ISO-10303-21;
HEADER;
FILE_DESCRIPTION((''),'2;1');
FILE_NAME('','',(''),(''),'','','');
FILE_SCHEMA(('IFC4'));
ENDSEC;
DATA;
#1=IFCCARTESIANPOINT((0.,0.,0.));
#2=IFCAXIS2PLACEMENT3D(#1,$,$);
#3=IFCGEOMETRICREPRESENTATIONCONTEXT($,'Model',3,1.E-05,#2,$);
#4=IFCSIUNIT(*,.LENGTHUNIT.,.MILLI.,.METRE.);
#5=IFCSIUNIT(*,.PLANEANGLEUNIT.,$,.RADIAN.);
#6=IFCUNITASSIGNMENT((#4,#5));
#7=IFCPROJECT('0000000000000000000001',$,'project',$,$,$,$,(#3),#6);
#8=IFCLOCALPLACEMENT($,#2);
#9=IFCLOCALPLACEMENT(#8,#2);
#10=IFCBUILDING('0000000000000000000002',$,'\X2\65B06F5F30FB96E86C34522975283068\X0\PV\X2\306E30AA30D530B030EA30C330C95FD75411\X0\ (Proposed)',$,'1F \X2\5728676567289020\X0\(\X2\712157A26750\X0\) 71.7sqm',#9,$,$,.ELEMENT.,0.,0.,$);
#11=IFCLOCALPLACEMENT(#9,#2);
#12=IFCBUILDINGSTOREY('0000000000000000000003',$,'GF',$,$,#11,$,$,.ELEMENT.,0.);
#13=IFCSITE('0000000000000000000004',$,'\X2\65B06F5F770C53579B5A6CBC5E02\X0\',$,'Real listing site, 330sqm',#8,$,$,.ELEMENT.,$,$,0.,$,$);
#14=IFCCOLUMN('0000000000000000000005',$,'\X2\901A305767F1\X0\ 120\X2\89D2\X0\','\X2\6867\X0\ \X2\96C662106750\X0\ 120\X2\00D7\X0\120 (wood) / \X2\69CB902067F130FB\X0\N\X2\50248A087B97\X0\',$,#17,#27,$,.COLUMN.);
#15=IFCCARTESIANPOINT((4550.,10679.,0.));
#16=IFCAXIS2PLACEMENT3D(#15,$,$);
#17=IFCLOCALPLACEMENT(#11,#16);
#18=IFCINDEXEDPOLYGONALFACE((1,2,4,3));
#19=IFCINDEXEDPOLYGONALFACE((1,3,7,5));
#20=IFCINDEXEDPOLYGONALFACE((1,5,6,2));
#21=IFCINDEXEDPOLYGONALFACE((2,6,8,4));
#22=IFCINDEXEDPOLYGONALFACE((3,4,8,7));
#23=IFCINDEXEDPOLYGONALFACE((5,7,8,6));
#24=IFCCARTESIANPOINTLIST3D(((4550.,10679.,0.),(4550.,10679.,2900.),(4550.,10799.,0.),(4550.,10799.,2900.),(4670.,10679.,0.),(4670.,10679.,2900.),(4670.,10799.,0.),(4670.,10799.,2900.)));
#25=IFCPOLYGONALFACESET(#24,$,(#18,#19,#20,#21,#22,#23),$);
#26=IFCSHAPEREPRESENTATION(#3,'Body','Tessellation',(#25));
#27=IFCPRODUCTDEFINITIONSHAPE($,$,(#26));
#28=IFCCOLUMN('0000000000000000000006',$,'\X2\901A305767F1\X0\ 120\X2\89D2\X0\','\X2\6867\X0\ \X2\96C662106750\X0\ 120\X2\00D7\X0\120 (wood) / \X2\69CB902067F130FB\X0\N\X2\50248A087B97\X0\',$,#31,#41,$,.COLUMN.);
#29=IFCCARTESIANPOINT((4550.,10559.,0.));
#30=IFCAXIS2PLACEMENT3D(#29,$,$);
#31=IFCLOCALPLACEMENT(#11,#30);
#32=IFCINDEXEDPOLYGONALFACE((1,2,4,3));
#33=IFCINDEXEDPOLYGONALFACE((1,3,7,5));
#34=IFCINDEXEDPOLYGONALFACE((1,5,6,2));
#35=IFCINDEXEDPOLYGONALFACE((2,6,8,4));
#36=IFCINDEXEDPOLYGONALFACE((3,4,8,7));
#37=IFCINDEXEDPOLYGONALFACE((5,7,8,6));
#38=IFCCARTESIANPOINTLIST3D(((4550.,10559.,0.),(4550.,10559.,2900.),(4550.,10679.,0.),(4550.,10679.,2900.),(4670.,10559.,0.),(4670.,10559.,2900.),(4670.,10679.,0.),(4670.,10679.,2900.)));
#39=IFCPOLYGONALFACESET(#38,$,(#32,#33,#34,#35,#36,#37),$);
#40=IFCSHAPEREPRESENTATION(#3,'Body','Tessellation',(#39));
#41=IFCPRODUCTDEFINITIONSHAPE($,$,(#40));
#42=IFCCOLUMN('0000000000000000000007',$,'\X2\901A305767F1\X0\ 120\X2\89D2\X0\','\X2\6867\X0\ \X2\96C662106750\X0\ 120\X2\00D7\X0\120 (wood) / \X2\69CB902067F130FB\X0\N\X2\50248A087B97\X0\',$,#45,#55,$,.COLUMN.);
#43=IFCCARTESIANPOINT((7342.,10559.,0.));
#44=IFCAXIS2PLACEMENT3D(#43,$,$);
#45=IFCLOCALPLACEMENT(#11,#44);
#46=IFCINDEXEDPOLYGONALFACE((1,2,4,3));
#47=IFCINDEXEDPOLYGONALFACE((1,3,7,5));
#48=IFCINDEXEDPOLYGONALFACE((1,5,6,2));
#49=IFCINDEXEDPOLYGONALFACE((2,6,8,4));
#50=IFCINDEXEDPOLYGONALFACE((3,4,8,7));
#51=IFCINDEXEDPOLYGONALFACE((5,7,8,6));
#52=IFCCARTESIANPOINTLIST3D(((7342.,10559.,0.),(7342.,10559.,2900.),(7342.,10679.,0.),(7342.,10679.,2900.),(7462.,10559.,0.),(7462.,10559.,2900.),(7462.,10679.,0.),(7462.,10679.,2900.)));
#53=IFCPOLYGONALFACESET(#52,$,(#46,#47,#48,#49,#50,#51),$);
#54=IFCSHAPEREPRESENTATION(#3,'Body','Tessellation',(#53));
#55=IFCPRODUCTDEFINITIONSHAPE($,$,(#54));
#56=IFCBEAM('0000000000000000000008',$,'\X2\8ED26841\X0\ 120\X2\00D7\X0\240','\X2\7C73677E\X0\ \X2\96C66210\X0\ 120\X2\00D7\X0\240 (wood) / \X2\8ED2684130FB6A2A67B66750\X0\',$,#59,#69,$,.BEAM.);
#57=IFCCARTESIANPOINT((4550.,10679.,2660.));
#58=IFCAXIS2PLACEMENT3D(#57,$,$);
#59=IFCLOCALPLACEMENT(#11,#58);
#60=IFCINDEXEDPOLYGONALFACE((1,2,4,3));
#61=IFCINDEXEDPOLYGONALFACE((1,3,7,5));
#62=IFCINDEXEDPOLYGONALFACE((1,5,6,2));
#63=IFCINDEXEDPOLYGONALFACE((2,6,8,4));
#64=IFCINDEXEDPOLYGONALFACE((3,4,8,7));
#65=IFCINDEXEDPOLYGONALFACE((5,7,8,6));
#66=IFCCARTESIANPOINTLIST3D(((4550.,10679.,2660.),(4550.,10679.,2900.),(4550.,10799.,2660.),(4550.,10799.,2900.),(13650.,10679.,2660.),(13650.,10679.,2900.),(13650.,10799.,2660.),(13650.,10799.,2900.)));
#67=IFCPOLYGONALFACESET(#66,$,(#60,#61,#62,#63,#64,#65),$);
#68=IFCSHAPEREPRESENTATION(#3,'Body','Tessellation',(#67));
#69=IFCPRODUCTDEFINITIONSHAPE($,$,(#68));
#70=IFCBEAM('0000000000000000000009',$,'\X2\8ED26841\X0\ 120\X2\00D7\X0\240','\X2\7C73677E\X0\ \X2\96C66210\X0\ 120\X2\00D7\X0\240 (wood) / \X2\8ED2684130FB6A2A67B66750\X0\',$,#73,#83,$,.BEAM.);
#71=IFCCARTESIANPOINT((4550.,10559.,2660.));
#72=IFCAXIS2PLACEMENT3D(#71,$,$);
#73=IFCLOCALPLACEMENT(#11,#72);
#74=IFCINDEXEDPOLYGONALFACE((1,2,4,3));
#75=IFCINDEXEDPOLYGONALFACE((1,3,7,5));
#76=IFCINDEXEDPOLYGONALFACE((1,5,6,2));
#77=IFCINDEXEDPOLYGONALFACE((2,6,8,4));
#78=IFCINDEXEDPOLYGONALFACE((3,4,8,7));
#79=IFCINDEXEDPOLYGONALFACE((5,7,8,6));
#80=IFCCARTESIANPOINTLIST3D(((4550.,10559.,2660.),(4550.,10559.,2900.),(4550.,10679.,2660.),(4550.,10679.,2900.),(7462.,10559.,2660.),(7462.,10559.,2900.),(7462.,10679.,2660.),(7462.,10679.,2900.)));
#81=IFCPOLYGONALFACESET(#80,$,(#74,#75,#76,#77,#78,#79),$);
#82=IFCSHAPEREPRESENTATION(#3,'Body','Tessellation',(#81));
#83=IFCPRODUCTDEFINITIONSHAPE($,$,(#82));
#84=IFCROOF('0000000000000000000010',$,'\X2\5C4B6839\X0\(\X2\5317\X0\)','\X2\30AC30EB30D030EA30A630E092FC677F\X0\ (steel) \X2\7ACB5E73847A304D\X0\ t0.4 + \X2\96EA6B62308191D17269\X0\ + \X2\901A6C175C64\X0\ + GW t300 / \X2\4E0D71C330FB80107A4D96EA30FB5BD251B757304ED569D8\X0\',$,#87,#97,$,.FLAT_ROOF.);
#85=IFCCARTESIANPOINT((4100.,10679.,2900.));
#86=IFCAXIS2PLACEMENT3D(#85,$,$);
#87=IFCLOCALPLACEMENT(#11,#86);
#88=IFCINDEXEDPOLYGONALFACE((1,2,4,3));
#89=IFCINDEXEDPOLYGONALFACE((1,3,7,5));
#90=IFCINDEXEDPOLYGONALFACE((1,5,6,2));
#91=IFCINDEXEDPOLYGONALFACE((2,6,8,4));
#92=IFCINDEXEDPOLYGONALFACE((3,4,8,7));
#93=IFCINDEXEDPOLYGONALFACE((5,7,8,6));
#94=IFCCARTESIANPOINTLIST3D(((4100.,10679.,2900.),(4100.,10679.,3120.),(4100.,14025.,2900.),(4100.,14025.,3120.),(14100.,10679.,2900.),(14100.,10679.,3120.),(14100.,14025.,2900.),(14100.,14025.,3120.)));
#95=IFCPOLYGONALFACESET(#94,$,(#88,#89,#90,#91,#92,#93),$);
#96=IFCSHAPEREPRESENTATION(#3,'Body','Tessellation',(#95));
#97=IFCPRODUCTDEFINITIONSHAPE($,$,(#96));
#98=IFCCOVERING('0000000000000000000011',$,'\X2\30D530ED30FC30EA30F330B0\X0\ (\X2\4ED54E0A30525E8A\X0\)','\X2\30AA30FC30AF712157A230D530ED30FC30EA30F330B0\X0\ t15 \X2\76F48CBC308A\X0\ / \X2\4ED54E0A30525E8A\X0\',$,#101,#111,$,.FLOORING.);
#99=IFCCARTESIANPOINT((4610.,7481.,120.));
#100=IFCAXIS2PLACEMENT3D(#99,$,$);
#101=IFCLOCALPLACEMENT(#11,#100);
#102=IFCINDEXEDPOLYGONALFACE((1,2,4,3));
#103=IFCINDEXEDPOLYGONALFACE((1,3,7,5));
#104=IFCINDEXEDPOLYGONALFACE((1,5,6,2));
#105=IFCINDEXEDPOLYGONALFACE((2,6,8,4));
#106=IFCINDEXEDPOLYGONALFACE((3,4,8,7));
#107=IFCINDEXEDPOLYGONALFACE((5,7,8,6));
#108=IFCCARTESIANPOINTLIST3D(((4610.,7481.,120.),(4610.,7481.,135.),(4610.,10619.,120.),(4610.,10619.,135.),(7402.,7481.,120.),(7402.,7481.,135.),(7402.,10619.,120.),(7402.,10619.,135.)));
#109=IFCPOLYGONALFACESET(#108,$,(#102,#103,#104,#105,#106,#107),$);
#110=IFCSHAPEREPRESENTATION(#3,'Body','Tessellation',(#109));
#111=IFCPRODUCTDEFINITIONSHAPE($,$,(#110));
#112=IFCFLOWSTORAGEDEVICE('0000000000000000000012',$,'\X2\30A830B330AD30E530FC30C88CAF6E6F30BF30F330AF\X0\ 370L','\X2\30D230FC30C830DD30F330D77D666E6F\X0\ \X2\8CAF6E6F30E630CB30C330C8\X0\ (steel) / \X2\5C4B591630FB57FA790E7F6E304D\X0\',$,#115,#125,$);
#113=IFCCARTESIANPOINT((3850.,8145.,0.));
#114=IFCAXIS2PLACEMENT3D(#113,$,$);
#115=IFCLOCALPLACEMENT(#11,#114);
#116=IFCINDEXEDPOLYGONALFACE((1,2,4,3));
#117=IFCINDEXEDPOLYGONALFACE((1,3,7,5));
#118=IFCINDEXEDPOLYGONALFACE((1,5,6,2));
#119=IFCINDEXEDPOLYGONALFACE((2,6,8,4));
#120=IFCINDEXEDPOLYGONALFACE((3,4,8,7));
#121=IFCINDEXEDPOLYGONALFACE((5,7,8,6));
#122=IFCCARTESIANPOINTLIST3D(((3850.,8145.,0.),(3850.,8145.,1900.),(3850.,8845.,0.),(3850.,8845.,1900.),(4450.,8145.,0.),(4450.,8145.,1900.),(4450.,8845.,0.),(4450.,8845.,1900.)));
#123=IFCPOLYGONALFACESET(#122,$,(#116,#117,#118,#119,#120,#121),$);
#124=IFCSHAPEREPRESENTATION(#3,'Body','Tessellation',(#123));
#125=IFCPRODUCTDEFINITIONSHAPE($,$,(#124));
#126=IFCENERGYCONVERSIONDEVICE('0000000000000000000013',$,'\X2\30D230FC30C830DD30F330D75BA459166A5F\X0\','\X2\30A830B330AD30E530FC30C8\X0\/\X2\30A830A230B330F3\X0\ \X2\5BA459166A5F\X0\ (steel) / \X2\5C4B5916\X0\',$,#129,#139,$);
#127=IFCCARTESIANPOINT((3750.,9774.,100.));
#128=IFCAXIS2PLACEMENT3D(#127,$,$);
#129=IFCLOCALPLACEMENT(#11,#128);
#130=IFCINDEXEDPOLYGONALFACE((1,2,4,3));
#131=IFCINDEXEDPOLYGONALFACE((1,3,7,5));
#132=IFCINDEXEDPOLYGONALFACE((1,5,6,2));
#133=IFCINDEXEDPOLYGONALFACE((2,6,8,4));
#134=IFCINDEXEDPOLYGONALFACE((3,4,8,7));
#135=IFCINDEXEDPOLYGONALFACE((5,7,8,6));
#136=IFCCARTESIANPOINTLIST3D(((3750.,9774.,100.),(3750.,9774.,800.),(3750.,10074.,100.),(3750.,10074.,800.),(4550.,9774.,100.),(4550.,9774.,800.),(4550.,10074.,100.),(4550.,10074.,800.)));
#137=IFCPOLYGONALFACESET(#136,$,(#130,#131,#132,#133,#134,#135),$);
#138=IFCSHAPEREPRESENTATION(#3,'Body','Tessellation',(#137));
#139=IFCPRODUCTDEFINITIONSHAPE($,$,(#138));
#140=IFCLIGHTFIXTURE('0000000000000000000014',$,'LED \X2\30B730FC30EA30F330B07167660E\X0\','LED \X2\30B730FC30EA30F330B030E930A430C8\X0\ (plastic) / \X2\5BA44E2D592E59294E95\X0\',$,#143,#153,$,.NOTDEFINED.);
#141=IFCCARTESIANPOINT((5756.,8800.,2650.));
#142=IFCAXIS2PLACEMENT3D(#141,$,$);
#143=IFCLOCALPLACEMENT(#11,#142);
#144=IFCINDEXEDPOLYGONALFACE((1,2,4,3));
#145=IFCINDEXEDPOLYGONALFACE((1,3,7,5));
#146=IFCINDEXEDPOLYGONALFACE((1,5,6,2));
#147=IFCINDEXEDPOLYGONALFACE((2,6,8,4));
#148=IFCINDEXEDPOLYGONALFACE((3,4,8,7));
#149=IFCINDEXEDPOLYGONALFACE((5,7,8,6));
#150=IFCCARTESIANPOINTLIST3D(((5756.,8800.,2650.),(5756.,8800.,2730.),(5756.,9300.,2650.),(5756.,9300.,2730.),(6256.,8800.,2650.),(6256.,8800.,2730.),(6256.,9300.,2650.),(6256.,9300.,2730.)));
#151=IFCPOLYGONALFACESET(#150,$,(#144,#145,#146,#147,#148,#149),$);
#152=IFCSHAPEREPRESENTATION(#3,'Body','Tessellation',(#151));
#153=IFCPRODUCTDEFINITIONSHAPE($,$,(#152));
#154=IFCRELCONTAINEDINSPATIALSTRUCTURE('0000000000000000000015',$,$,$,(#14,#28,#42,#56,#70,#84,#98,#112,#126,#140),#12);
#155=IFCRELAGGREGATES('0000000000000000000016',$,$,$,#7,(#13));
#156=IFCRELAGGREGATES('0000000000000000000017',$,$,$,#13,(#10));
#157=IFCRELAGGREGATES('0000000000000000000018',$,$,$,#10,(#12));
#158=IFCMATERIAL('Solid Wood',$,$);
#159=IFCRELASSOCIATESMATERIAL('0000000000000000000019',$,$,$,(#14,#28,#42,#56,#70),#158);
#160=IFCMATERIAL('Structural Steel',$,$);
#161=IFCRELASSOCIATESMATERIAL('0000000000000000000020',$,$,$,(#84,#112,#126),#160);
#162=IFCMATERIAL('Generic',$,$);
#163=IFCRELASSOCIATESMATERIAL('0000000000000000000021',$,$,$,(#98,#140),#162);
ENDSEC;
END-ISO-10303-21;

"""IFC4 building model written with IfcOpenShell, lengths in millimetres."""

from ifc_helpers import new_model, si_unit, frame, frame_2d, origin, place, context, project, spatial, rectangle, extrude, material, element, save


model = new_model("IFC4")

# Units and contexts
model_context = context("Model", 3, precision=1e-05, world=origin())
ifc_project = project(units=[si_unit("LENGTHUNIT", "METRE", prefix="MILLI"), si_unit("PLANEANGLEUNIT", "RADIAN")], contexts=[model_context])

# Site, building, storey
site_placement = place(None, origin())
site = spatial("IfcSite", under=ifc_project, at=site_placement, Name="新潟県南魚沼市", ObjectType="Real listing site, 330sqm", CompositionType="ELEMENT", RefElevation=0.0)
building_placement = place(site_placement, origin())
building = spatial("IfcBuilding", under=site, at=building_placement, Name="新潟・雨水利用とPVのオフグリッド志向 (Proposed)", ObjectType="1F 在来木造(無垢材) 71.7sqm", CompositionType="ELEMENT", ElevationOfRefHeight=0.0, ElevationOfTerrain=0.0)
storey_placement = place(building_placement, origin())
storey = spatial("IfcBuildingStorey", under=building, at=storey_placement, Name="GF", CompositionType="ELEMENT", Elevation=0.0)

# Columns
ifc_material_1 = material(Name="Solid Wood")
column_1_placement = place(storey_placement, frame((4550.0, 10679.0, 0.0)))
element("IfcColumn", 1, at=column_1_placement, inside=storey, material=ifc_material_1, Name="通し柱 120角", Description="桧 集成材 120×120 (wood) / 構造柱・N値計算", PredefinedType="COLUMN", context=model_context, shape_type="SweptSolid", body=[
    extrude(rectangle(XDim=120.0, YDim=120.0, at=frame_2d((60.0, 60.0))), frame((4550.0, 10679.0, 0.0)), (0.0, 0.0, 1.0), 2900.0),
])
column_2_placement = place(storey_placement, frame((4550.0, 10559.0, 0.0)))
element("IfcColumn", 2, at=column_2_placement, inside=storey, material=ifc_material_1, Name="通し柱 120角", Description="桧 集成材 120×120 (wood) / 構造柱・N値計算", PredefinedType="COLUMN", context=model_context, shape_type="SweptSolid", body=[
    extrude(rectangle(XDim=120.0, YDim=120.0, at=frame_2d((60.0, 60.0))), frame((4550.0, 10559.0, 0.0)), (0.0, 0.0, 1.0), 2900.0),
])
column_3_placement = place(storey_placement, frame((7342.0, 10559.0, 0.0)))
element("IfcColumn", 3, at=column_3_placement, inside=storey, material=ifc_material_1, Name="通し柱 120角", Description="桧 集成材 120×120 (wood) / 構造柱・N値計算", PredefinedType="COLUMN", context=model_context, shape_type="SweptSolid", body=[
    extrude(rectangle(XDim=120.0, YDim=120.0, at=frame_2d((60.0, 60.0))), frame((7342.0, 10559.0, 0.0)), (0.0, 0.0, 1.0), 2900.0),
])

# Beams
beam_1_placement = place(storey_placement, frame((4550.0, 10679.0, 2660.0)))
element("IfcBeam", 4, at=beam_1_placement, inside=storey, material=ifc_material_1, Name="軒桁 120×240", Description="米松 集成 120×240 (wood) / 軒桁・横架材", PredefinedType="BEAM", context=model_context, shape_type="SweptSolid", body=[
    extrude(rectangle(XDim=9100.0, YDim=120.0, at=frame_2d((4550.0, 60.0))), frame((4550.0, 10679.0, 2660.0)), (0.0, 0.0, 1.0), 240.0),
])
beam_2_placement = place(storey_placement, frame((4550.0, 10559.0, 2660.0)))
element("IfcBeam", 5, at=beam_2_placement, inside=storey, material=ifc_material_1, Name="軒桁 120×240", Description="米松 集成 120×240 (wood) / 軒桁・横架材", PredefinedType="BEAM", context=model_context, shape_type="SweptSolid", body=[
    extrude(rectangle(XDim=2912.0, YDim=120.0, at=frame_2d((1456.0, 60.0))), frame((4550.0, 10559.0, 2660.0)), (0.0, 0.0, 1.0), 240.0),
])

# Roof
ifc_material_2 = material(Name="Structural Steel")
roof_placement = place(storey_placement, frame((4100.0, 10679.0, 2900.0)))
element("IfcRoof", 6, at=roof_placement, inside=storey, material=ifc_material_2, Name="屋根(北)", Description="ガルバリウム鋼板 (steel) 立平葺き t0.4 + 雪止め金物 + 通気層 + GW t300 / 不燃・耐積雪・寒冷地仕様", PredefinedType="FLAT_ROOF", context=model_context, shape_type="SweptSolid", body=[
    extrude(rectangle(XDim=10000.0, YDim=3346.0, at=frame_2d((5000.0, 1673.0))), frame((4100.0, 10679.0, 2900.0)), (0.0, 0.0, 1.0), 220.0),
])

# Covering
ifc_material_3 = material(Name="Generic")
covering_placement = place(storey_placement, frame((4610.0, 7481.0, 120.0)))
element("IfcCovering", 7, at=covering_placement, inside=storey, material=ifc_material_3, Name="フローリング (仕上げ床)", Description="オーク無垢フローリング t15 直貼り / 仕上げ床", PredefinedType="FLOORING", context=model_context, shape_type="SweptSolid", body=[
    extrude(rectangle(XDim=2792.0, YDim=3138.0, at=frame_2d((1396.0, 1569.0))), frame((4610.0, 7481.0, 120.0)), (0.0, 0.0, 1.0), 15.0),
])

# Flow storage device
flow_storage_device_placement = place(storey_placement, frame((3850.0, 8145.0, 0.0)))
element("IfcFlowStorageDevice", 8, at=flow_storage_device_placement, inside=storey, material=ifc_material_2, Name="エコキュート貯湯タンク 370L", Description="ヒートポンプ給湯 貯湯ユニット (steel) / 屋外・基礎置き", context=model_context, shape_type="SweptSolid", body=[
    extrude(rectangle(XDim=600.0, YDim=700.0, at=frame_2d((300.0, 350.0))), frame((3850.0, 8145.0, 0.0)), (0.0, 0.0, 1.0), 1900.0),
])

# Energy conversion device
energy_conversion_device_placement = place(storey_placement, frame((3750.0, 9774.0, 100.0)))
element("IfcEnergyConversionDevice", 9, at=energy_conversion_device_placement, inside=storey, material=ifc_material_2, Name="ヒートポンプ室外機", Description="エコキュート/エアコン 室外機 (steel) / 屋外", context=model_context, shape_type="SweptSolid", body=[
    extrude(rectangle(XDim=800.0, YDim=300.0, at=frame_2d((400.0, 150.0))), frame((3750.0, 9774.0, 100.0)), (0.0, 0.0, 1.0), 700.0),
])

# Light fixture
light_fixture_placement = place(storey_placement, frame((5756.0, 8800.0, 2650.0)))
element("IfcLightFixture", 10, at=light_fixture_placement, inside=storey, material=ifc_material_3, Name="LED シーリング照明", Description="LED シーリングライト (plastic) / 室中央天井", PredefinedType="NOTDEFINED", context=model_context, shape_type="SweptSolid", body=[
    extrude(rectangle(XDim=500.0, YDim=500.0, at=frame_2d((250.0, 250.0))), frame((5756.0, 8800.0, 2650.0)), (0.0, 0.0, 1.0), 80.0),
])

save(model, "model.ifc")
